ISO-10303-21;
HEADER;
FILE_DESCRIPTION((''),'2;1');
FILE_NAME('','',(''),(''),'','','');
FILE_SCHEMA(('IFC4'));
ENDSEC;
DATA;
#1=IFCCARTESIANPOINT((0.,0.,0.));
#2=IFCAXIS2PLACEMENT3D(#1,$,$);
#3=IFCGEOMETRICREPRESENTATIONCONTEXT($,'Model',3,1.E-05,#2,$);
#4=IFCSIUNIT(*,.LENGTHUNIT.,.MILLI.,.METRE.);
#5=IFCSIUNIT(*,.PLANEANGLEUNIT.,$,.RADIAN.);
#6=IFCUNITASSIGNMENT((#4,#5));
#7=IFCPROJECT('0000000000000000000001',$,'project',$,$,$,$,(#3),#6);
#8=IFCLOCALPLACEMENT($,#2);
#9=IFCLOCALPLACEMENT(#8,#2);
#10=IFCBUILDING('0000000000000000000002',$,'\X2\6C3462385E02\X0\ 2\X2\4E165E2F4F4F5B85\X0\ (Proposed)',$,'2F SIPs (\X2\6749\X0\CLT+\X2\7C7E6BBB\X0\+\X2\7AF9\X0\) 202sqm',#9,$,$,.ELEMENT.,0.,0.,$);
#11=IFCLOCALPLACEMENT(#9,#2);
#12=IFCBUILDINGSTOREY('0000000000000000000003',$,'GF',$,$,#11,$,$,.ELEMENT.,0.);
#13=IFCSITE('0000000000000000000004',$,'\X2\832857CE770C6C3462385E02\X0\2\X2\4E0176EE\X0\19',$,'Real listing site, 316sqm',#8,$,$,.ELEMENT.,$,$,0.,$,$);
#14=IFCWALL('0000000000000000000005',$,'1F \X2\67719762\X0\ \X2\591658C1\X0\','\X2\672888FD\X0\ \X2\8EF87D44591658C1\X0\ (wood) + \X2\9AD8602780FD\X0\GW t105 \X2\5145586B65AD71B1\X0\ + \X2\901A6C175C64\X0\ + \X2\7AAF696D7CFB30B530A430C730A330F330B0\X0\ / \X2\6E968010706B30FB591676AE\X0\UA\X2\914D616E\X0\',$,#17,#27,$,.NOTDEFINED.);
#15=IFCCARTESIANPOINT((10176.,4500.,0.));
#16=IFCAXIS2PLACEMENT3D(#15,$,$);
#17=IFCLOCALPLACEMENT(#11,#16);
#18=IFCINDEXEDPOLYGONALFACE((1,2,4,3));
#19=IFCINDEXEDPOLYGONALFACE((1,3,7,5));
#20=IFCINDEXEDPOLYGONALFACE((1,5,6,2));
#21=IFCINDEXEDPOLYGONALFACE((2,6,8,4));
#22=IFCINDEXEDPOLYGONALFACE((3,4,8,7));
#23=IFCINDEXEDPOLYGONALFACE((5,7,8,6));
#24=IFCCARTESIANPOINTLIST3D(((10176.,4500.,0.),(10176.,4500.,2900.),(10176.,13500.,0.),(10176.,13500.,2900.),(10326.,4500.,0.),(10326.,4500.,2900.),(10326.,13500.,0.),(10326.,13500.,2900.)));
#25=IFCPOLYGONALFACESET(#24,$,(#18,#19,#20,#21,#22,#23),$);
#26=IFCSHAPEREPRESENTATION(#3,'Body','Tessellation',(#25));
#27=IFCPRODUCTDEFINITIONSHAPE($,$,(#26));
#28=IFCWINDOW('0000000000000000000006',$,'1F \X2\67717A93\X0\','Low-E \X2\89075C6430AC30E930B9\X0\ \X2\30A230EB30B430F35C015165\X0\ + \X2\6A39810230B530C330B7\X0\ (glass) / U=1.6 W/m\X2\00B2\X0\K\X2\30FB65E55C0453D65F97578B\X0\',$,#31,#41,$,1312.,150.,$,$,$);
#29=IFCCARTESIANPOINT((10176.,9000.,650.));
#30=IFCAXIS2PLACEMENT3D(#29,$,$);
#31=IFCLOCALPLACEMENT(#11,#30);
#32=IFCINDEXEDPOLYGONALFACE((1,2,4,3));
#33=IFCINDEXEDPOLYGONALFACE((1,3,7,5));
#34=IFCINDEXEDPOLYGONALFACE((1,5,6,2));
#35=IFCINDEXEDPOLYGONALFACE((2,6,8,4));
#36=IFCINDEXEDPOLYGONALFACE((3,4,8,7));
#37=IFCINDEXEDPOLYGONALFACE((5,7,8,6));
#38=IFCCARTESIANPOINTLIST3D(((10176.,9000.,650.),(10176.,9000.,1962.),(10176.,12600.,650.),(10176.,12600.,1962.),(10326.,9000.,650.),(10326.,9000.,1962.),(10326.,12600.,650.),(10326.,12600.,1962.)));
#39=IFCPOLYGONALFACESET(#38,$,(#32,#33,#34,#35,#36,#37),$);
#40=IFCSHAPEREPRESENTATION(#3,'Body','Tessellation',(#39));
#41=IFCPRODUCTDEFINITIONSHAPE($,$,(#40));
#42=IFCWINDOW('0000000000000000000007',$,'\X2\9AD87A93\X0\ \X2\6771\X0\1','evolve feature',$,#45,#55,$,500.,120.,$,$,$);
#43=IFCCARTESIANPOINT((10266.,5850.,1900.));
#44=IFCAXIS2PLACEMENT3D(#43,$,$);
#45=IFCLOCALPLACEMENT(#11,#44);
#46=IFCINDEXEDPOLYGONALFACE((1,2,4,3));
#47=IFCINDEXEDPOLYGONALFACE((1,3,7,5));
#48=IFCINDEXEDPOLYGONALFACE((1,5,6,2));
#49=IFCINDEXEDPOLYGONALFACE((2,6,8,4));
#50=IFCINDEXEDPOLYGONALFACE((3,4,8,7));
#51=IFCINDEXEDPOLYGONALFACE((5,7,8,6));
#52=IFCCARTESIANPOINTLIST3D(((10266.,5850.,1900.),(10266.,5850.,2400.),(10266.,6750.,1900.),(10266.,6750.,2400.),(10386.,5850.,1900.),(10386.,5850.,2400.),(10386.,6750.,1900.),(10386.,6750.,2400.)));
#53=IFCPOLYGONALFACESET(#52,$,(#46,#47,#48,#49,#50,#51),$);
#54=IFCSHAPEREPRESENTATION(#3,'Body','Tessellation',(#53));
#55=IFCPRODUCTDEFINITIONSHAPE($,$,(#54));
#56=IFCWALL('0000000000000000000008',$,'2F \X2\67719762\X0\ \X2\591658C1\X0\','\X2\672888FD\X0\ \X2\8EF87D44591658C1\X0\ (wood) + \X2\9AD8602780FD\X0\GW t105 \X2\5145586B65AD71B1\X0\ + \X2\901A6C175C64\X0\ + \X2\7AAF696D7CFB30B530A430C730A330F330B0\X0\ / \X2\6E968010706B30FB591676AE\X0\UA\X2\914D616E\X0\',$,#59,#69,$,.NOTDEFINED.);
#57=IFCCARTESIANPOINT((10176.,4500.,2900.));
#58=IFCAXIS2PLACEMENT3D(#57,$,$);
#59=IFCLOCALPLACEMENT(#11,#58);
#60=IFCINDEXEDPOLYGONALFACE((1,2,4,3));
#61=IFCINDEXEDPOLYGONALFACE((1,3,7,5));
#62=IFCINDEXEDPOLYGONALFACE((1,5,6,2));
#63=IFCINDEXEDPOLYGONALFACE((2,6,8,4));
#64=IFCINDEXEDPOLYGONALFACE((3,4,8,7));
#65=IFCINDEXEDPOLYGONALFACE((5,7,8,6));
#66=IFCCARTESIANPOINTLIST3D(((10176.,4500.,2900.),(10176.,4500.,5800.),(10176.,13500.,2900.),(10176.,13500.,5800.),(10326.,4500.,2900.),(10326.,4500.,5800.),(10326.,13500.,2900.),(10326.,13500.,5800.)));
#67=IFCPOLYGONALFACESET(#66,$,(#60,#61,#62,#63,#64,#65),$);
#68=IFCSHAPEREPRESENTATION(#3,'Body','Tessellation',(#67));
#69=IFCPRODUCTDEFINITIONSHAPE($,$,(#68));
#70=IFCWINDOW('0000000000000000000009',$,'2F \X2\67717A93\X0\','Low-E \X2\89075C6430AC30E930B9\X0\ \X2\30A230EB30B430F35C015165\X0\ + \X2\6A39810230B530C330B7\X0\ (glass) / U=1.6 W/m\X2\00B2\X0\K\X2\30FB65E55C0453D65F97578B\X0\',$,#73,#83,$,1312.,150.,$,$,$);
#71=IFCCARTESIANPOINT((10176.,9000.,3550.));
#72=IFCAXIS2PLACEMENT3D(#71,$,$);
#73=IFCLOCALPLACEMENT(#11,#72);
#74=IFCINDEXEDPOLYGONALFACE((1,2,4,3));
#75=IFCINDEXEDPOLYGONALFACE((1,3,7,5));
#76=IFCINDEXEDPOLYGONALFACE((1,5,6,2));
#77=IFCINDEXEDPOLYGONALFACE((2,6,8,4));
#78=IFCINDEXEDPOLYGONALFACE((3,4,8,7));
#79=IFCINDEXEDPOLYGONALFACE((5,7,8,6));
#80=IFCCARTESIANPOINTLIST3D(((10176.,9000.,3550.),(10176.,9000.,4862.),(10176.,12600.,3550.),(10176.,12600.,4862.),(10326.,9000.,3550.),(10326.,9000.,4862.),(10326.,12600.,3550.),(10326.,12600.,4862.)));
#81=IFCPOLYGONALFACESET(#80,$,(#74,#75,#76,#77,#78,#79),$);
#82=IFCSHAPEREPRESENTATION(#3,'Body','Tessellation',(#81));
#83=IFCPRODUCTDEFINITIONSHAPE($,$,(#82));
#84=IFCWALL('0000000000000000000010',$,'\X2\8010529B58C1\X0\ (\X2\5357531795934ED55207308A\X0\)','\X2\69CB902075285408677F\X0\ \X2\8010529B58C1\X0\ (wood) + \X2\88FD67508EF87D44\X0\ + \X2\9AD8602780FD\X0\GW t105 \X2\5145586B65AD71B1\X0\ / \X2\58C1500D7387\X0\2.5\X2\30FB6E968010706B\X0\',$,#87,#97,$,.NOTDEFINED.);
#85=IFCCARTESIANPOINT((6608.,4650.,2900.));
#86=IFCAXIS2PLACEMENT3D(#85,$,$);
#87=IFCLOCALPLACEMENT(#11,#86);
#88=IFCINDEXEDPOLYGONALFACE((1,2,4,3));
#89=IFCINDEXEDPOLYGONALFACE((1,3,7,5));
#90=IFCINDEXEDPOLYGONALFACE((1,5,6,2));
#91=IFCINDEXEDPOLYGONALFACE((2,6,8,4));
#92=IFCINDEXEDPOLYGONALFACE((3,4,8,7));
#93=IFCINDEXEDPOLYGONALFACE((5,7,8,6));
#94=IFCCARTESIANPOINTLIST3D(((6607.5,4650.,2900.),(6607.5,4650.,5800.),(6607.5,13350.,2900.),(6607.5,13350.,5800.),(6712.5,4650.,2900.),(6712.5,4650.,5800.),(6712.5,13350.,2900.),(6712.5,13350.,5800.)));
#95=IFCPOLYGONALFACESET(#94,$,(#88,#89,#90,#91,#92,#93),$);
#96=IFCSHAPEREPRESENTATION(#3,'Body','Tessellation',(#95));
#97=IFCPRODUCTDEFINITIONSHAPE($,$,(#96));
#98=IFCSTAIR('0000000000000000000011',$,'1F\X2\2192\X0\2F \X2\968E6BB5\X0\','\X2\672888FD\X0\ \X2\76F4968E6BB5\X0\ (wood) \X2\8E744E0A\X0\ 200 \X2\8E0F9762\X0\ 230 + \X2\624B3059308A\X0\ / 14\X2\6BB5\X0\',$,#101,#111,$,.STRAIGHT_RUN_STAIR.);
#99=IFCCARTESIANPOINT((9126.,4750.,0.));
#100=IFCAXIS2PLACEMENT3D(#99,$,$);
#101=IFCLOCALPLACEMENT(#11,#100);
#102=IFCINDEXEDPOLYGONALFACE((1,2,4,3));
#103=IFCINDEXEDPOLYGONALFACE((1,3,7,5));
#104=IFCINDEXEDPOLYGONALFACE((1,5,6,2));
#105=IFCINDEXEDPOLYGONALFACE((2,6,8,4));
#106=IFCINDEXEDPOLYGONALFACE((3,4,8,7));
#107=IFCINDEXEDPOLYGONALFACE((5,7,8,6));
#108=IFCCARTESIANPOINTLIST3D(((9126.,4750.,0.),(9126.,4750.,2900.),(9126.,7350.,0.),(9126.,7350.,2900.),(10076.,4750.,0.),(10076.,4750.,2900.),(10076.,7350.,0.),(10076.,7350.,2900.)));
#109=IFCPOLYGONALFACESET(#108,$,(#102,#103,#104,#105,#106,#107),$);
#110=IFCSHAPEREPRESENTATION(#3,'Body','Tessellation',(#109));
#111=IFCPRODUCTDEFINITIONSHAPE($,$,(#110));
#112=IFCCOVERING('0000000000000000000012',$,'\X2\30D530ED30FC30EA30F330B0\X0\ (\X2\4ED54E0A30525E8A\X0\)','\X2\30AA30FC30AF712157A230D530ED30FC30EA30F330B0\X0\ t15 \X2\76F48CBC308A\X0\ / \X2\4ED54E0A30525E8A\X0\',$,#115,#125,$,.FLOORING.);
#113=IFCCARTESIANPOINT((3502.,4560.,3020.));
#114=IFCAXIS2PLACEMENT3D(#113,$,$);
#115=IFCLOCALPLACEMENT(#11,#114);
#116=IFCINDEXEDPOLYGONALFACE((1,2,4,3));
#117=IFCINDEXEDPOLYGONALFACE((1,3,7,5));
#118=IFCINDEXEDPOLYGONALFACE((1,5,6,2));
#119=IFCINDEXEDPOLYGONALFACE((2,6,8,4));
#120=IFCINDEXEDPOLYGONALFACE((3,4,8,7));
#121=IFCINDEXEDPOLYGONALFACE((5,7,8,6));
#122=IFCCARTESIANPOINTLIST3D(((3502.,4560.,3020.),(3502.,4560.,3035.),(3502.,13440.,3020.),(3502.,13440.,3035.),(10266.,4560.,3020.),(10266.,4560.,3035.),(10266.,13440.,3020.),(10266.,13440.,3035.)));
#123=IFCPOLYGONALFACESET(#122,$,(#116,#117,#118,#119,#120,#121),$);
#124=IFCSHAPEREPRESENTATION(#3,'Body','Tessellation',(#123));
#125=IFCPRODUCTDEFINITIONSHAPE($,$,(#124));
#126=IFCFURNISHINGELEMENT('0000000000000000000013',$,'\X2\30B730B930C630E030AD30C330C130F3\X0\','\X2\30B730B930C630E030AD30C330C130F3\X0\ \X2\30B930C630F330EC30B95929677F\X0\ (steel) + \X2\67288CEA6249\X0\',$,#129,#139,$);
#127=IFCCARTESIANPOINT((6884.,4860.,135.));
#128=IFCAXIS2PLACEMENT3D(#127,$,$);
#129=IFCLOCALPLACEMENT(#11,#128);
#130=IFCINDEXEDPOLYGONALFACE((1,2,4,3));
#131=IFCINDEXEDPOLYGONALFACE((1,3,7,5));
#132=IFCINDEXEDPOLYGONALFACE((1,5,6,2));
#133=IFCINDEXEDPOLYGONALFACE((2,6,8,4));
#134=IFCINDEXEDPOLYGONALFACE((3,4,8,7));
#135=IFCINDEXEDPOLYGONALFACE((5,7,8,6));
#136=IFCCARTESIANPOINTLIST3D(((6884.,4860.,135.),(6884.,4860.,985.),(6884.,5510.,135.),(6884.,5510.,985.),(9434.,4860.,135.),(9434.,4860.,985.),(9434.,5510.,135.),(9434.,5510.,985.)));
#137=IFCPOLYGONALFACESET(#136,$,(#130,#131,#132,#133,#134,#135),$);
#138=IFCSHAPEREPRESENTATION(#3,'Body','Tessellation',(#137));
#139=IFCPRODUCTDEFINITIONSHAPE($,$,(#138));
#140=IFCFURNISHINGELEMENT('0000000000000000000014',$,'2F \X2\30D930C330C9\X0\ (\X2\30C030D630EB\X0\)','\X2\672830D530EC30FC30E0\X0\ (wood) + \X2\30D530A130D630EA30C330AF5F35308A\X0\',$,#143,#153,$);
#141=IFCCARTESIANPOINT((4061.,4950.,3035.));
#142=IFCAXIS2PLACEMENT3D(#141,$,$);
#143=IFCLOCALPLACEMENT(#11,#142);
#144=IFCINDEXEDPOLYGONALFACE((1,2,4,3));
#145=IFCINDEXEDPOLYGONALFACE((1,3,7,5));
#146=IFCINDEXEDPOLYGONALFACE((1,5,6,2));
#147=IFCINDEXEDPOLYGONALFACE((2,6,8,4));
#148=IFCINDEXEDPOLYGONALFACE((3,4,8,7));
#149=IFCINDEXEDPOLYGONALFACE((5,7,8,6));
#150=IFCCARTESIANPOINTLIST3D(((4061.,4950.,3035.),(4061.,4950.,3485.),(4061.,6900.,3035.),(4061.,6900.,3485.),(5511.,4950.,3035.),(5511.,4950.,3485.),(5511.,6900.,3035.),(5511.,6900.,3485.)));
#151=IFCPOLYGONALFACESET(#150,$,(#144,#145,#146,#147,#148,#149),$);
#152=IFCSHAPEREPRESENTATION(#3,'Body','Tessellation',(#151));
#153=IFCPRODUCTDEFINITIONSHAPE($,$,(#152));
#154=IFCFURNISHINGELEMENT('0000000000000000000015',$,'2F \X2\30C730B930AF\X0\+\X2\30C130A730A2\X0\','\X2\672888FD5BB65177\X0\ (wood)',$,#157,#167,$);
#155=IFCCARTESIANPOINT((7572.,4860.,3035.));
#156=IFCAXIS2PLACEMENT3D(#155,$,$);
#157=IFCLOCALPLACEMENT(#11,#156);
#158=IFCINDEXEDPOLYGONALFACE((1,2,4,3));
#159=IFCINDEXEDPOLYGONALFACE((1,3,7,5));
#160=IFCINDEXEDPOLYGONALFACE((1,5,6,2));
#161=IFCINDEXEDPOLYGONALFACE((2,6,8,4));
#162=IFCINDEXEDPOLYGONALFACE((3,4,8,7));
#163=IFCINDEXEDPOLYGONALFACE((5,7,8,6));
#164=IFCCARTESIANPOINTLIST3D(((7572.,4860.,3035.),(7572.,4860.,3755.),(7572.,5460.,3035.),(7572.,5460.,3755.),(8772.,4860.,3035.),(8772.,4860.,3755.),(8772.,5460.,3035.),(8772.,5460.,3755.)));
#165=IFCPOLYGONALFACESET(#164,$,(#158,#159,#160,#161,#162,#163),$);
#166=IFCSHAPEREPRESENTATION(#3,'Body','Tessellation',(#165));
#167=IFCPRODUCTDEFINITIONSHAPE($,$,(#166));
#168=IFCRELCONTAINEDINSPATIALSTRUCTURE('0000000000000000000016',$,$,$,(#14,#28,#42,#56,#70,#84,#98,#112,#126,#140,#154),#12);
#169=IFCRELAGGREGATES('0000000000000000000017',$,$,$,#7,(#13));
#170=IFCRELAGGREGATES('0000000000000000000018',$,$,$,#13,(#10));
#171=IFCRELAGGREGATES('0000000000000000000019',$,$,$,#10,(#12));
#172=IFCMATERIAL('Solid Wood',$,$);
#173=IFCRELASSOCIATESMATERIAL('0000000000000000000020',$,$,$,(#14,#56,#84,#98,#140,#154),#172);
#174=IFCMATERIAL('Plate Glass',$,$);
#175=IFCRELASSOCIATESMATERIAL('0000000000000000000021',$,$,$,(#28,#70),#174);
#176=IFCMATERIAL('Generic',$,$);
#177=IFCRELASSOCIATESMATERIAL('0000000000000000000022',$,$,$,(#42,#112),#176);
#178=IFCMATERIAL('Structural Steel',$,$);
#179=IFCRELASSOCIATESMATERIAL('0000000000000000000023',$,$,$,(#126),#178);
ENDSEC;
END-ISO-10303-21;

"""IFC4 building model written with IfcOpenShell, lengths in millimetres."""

from ifc_helpers import new_model, si_unit, frame, frame_2d, origin, place, context, project, spatial, rectangle, extrude, material, element, fill, save


model = new_model("IFC4")

# Units and contexts
model_context = context("Model", 3, precision=1e-05, world=origin())
ifc_project = project(units=[si_unit("LENGTHUNIT", "METRE", prefix="MILLI"), si_unit("PLANEANGLEUNIT", "RADIAN")], contexts=[model_context])

# Site, building, storey
site_placement = place(None, origin())
site = spatial("IfcSite", under=ifc_project, at=site_placement, Name="茨城県水戸市2丁目19", ObjectType="Real listing site, 316sqm", CompositionType="ELEMENT", RefElevation=0.0)
building_placement = place(site_placement, origin())
building = spatial("IfcBuilding", under=site, at=building_placement, Name="水戸市 2世帯住宅 (Proposed)", ObjectType="2F SIPs (杉CLT+籾殻+竹) 202sqm", CompositionType="ELEMENT", ElevationOfRefHeight=0.0, ElevationOfTerrain=0.0)
storey_placement = place(building_placement, origin())
storey = spatial("IfcBuildingStorey", under=building, at=storey_placement, Name="GF", CompositionType="ELEMENT", Elevation=0.0)

# Shared definitions
ifc_material_1 = material(Name="Solid Wood")

# Wall, openings, windows
wall_1_placement = place(storey_placement, frame((10176.0, 4500.0, 0.0)))
wall_1 = element("IfcWall", 1, at=wall_1_placement, inside=storey, material=ifc_material_1, Name="1F 東面 外壁", Description="木製 軸組外壁 (wood) + 高性能GW t105 充填断熱 + 通気層 + 窯業系サイディング / 準耐火・外皮UA配慮", PredefinedType="NOTDEFINED", context=model_context, shape_type="SweptSolid", body=[
    extrude(rectangle(XDim=150.0, YDim=9000.0, at=frame_2d((75.0, 4500.0))), frame((10176.0, 4500.0, 0.0)), (0.0, 0.0, 1.0), 2900.0),
])
opening_1_placement = place(storey_placement, frame((10176.0, 9000.0, 650.0)))
opening_1 = element("IfcOpeningElement", 2, at=opening_1_placement, cuts=wall_1, PredefinedType="NOTDEFINED", context=model_context, shape_type="SweptSolid", body=[
    extrude(rectangle(XDim=150.0, YDim=3600.0, at=frame_2d((75.0, 1800.0))), frame((10176.0, 9000.0, 650.0)), (0.0, 0.0, 1.0), 1312.0),
])
opening_2_placement = place(storey_placement, frame((10266.0, 5850.0, 1900.0)))
opening_2 = element("IfcOpeningElement", 3, at=opening_2_placement, cuts=wall_1, PredefinedType="NOTDEFINED", context=model_context, shape_type="SweptSolid", body=[
    extrude(rectangle(XDim=120.0, YDim=900.0, at=frame_2d((60.0, 450.0))), frame((10266.0, 5850.0, 1900.0)), (0.0, 0.0, 1.0), 500.0),
])
ifc_material_2 = material(Name="Plate Glass")
window_1_placement = place(storey_placement, frame((10176.0, 9000.0, 650.0)))
window_1 = element("IfcWindow", 4, at=window_1_placement, inside=storey, material=ifc_material_2, Name="1F 東窓", Description="Low-E 複層ガラス アルゴン封入 + 樹脂サッシ (glass) / U=1.6 W/m²K・日射取得型", OverallHeight=1312.0, OverallWidth=150.0, context=model_context, shape_type="SweptSolid", body=[
    extrude(rectangle(XDim=150.0, YDim=3600.0, at=frame_2d((75.0, 1800.0))), frame((10176.0, 9000.0, 650.0)), (0.0, 0.0, 1.0), 1312.0),
])
fill(opening_1, window_1)
ifc_material_3 = material(Name="Generic")
window_2_placement = place(storey_placement, frame((10266.0, 5850.0, 1900.0)))
window_2 = element("IfcWindow", 5, at=window_2_placement, inside=storey, material=ifc_material_3, Name="高窓 東1", Description="evolve feature", OverallHeight=500.0, OverallWidth=120.0, context=model_context, shape_type="SweptSolid", body=[
    extrude(rectangle(XDim=120.0, YDim=900.0, at=frame_2d((60.0, 450.0))), frame((10266.0, 5850.0, 1900.0)), (0.0, 0.0, 1.0), 500.0),
])
fill(opening_2, window_2)

# Wall, opening, window
wall_2_placement = place(storey_placement, frame((10176.0, 4500.0, 2900.0)))
wall_2 = element("IfcWall", 6, at=wall_2_placement, inside=storey, material=ifc_material_1, Name="2F 東面 外壁", Description="木製 軸組外壁 (wood) + 高性能GW t105 充填断熱 + 通気層 + 窯業系サイディング / 準耐火・外皮UA配慮", PredefinedType="NOTDEFINED", context=model_context, shape_type="SweptSolid", body=[
    extrude(rectangle(XDim=150.0, YDim=9000.0, at=frame_2d((75.0, 4500.0))), frame((10176.0, 4500.0, 2900.0)), (0.0, 0.0, 1.0), 2900.0),
])
opening_3_placement = place(storey_placement, frame((10176.0, 9000.0, 3550.0)))
opening_3 = element("IfcOpeningElement", 7, at=opening_3_placement, cuts=wall_2, PredefinedType="NOTDEFINED", context=model_context, shape_type="SweptSolid", body=[
    extrude(rectangle(XDim=150.0, YDim=3600.0, at=frame_2d((75.0, 1800.0))), frame((10176.0, 9000.0, 3550.0)), (0.0, 0.0, 1.0), 1312.0),
])
window_3_placement = place(storey_placement, frame((10176.0, 9000.0, 3550.0)))
window_3 = element("IfcWindow", 8, at=window_3_placement, inside=storey, material=ifc_material_2, Name="2F 東窓", Description="Low-E 複層ガラス アルゴン封入 + 樹脂サッシ (glass) / U=1.6 W/m²K・日射取得型", OverallHeight=1312.0, OverallWidth=150.0, context=model_context, shape_type="SweptSolid", body=[
    extrude(rectangle(XDim=150.0, YDim=3600.0, at=frame_2d((75.0, 1800.0))), frame((10176.0, 9000.0, 3550.0)), (0.0, 0.0, 1.0), 1312.0),
])
fill(opening_3, window_3)

# Wall
wall_3_placement = place(storey_placement, frame((6608.0, 4650.0, 2900.0)))
element("IfcWall", 9, at=wall_3_placement, inside=storey, material=ifc_material_1, Name="耐力壁 (南北間仕切り)", Description="構造用合板 耐力壁 (wood) + 製材軸組 + 高性能GW t105 充填断熱 / 壁倍率2.5・準耐火", PredefinedType="NOTDEFINED", context=model_context, shape_type="SweptSolid", body=[
    extrude(rectangle(XDim=105.0, YDim=8700.0, at=frame_2d((52.0, 4350.0))), frame((6608.0, 4650.0, 2900.0)), (0.0, 0.0, 1.0), 2900.0),
])

# Stair
stair_placement = place(storey_placement, frame((9126.0, 4750.0, 0.0)))
element("IfcStair", 10, at=stair_placement, inside=storey, material=ifc_material_1, Name="1F→2F 階段", Description="木製 直階段 (wood) 蹴上 200 踏面 230 + 手すり / 14段", PredefinedType="STRAIGHT_RUN_STAIR", context=model_context, shape_type="SweptSolid", body=[
    extrude(rectangle(XDim=950.0, YDim=2600.0, at=frame_2d((475.0, 1300.0))), frame((9126.0, 4750.0, 0.0)), (0.0, 0.0, 1.0), 2900.0),
])

# Covering
covering_placement = place(storey_placement, frame((3502.0, 4560.0, 3020.0)))
element("IfcCovering", 11, at=covering_placement, inside=storey, material=ifc_material_3, Name="フローリング (仕上げ床)", Description="オーク無垢フローリング t15 直貼り / 仕上げ床", PredefinedType="FLOORING", context=model_context, shape_type="SweptSolid", body=[
    extrude(rectangle(XDim=6764.0, YDim=8880.0, at=frame_2d((3382.0, 4440.0))), frame((3502.0, 4560.0, 3020.0)), (0.0, 0.0, 1.0), 15.0),
])

# Furnishing elements
ifc_material_4 = material(Name="Structural Steel")
furnishing_1_placement = place(storey_placement, frame((6884.0, 4860.0, 135.0)))
element("IfcFurnishingElement", 12, at=furnishing_1_placement, inside=storey, material=ifc_material_4, Name="システムキッチン", Description="システムキッチン ステンレス天板 (steel) + 木質扉", context=model_context, shape_type="SweptSolid", body=[
    extrude(rectangle(XDim=2550.0, YDim=650.0, at=frame_2d((1275.0, 325.0))), frame((6884.0, 4860.0, 135.0)), (0.0, 0.0, 1.0), 850.0),
])
furnishing_2_placement = place(storey_placement, frame((4061.0, 4950.0, 3035.0)))
element("IfcFurnishingElement", 13, at=furnishing_2_placement, inside=storey, material=ifc_material_1, Name="2F ベッド (ダブル)", Description="木フレーム (wood) + ファブリック張り", context=model_context, shape_type="SweptSolid", body=[
    extrude(rectangle(XDim=1450.0, YDim=1950.0, at=frame_2d((725.0, 975.0))), frame((4061.0, 4950.0, 3035.0)), (0.0, 0.0, 1.0), 450.0),
])
furnishing_3_placement = place(storey_placement, frame((7572.0, 4860.0, 3035.0)))
element("IfcFurnishingElement", 14, at=furnishing_3_placement, inside=storey, material=ifc_material_1, Name="2F デスク+チェア", Description="木製家具 (wood)", context=model_context, shape_type="SweptSolid", body=[
    extrude(rectangle(XDim=1200.0, YDim=600.0, at=frame_2d((600.0, 300.0))), frame((7572.0, 4860.0, 3035.0)), (0.0, 0.0, 1.0), 720.0),
])

save(model, "model.ifc")
